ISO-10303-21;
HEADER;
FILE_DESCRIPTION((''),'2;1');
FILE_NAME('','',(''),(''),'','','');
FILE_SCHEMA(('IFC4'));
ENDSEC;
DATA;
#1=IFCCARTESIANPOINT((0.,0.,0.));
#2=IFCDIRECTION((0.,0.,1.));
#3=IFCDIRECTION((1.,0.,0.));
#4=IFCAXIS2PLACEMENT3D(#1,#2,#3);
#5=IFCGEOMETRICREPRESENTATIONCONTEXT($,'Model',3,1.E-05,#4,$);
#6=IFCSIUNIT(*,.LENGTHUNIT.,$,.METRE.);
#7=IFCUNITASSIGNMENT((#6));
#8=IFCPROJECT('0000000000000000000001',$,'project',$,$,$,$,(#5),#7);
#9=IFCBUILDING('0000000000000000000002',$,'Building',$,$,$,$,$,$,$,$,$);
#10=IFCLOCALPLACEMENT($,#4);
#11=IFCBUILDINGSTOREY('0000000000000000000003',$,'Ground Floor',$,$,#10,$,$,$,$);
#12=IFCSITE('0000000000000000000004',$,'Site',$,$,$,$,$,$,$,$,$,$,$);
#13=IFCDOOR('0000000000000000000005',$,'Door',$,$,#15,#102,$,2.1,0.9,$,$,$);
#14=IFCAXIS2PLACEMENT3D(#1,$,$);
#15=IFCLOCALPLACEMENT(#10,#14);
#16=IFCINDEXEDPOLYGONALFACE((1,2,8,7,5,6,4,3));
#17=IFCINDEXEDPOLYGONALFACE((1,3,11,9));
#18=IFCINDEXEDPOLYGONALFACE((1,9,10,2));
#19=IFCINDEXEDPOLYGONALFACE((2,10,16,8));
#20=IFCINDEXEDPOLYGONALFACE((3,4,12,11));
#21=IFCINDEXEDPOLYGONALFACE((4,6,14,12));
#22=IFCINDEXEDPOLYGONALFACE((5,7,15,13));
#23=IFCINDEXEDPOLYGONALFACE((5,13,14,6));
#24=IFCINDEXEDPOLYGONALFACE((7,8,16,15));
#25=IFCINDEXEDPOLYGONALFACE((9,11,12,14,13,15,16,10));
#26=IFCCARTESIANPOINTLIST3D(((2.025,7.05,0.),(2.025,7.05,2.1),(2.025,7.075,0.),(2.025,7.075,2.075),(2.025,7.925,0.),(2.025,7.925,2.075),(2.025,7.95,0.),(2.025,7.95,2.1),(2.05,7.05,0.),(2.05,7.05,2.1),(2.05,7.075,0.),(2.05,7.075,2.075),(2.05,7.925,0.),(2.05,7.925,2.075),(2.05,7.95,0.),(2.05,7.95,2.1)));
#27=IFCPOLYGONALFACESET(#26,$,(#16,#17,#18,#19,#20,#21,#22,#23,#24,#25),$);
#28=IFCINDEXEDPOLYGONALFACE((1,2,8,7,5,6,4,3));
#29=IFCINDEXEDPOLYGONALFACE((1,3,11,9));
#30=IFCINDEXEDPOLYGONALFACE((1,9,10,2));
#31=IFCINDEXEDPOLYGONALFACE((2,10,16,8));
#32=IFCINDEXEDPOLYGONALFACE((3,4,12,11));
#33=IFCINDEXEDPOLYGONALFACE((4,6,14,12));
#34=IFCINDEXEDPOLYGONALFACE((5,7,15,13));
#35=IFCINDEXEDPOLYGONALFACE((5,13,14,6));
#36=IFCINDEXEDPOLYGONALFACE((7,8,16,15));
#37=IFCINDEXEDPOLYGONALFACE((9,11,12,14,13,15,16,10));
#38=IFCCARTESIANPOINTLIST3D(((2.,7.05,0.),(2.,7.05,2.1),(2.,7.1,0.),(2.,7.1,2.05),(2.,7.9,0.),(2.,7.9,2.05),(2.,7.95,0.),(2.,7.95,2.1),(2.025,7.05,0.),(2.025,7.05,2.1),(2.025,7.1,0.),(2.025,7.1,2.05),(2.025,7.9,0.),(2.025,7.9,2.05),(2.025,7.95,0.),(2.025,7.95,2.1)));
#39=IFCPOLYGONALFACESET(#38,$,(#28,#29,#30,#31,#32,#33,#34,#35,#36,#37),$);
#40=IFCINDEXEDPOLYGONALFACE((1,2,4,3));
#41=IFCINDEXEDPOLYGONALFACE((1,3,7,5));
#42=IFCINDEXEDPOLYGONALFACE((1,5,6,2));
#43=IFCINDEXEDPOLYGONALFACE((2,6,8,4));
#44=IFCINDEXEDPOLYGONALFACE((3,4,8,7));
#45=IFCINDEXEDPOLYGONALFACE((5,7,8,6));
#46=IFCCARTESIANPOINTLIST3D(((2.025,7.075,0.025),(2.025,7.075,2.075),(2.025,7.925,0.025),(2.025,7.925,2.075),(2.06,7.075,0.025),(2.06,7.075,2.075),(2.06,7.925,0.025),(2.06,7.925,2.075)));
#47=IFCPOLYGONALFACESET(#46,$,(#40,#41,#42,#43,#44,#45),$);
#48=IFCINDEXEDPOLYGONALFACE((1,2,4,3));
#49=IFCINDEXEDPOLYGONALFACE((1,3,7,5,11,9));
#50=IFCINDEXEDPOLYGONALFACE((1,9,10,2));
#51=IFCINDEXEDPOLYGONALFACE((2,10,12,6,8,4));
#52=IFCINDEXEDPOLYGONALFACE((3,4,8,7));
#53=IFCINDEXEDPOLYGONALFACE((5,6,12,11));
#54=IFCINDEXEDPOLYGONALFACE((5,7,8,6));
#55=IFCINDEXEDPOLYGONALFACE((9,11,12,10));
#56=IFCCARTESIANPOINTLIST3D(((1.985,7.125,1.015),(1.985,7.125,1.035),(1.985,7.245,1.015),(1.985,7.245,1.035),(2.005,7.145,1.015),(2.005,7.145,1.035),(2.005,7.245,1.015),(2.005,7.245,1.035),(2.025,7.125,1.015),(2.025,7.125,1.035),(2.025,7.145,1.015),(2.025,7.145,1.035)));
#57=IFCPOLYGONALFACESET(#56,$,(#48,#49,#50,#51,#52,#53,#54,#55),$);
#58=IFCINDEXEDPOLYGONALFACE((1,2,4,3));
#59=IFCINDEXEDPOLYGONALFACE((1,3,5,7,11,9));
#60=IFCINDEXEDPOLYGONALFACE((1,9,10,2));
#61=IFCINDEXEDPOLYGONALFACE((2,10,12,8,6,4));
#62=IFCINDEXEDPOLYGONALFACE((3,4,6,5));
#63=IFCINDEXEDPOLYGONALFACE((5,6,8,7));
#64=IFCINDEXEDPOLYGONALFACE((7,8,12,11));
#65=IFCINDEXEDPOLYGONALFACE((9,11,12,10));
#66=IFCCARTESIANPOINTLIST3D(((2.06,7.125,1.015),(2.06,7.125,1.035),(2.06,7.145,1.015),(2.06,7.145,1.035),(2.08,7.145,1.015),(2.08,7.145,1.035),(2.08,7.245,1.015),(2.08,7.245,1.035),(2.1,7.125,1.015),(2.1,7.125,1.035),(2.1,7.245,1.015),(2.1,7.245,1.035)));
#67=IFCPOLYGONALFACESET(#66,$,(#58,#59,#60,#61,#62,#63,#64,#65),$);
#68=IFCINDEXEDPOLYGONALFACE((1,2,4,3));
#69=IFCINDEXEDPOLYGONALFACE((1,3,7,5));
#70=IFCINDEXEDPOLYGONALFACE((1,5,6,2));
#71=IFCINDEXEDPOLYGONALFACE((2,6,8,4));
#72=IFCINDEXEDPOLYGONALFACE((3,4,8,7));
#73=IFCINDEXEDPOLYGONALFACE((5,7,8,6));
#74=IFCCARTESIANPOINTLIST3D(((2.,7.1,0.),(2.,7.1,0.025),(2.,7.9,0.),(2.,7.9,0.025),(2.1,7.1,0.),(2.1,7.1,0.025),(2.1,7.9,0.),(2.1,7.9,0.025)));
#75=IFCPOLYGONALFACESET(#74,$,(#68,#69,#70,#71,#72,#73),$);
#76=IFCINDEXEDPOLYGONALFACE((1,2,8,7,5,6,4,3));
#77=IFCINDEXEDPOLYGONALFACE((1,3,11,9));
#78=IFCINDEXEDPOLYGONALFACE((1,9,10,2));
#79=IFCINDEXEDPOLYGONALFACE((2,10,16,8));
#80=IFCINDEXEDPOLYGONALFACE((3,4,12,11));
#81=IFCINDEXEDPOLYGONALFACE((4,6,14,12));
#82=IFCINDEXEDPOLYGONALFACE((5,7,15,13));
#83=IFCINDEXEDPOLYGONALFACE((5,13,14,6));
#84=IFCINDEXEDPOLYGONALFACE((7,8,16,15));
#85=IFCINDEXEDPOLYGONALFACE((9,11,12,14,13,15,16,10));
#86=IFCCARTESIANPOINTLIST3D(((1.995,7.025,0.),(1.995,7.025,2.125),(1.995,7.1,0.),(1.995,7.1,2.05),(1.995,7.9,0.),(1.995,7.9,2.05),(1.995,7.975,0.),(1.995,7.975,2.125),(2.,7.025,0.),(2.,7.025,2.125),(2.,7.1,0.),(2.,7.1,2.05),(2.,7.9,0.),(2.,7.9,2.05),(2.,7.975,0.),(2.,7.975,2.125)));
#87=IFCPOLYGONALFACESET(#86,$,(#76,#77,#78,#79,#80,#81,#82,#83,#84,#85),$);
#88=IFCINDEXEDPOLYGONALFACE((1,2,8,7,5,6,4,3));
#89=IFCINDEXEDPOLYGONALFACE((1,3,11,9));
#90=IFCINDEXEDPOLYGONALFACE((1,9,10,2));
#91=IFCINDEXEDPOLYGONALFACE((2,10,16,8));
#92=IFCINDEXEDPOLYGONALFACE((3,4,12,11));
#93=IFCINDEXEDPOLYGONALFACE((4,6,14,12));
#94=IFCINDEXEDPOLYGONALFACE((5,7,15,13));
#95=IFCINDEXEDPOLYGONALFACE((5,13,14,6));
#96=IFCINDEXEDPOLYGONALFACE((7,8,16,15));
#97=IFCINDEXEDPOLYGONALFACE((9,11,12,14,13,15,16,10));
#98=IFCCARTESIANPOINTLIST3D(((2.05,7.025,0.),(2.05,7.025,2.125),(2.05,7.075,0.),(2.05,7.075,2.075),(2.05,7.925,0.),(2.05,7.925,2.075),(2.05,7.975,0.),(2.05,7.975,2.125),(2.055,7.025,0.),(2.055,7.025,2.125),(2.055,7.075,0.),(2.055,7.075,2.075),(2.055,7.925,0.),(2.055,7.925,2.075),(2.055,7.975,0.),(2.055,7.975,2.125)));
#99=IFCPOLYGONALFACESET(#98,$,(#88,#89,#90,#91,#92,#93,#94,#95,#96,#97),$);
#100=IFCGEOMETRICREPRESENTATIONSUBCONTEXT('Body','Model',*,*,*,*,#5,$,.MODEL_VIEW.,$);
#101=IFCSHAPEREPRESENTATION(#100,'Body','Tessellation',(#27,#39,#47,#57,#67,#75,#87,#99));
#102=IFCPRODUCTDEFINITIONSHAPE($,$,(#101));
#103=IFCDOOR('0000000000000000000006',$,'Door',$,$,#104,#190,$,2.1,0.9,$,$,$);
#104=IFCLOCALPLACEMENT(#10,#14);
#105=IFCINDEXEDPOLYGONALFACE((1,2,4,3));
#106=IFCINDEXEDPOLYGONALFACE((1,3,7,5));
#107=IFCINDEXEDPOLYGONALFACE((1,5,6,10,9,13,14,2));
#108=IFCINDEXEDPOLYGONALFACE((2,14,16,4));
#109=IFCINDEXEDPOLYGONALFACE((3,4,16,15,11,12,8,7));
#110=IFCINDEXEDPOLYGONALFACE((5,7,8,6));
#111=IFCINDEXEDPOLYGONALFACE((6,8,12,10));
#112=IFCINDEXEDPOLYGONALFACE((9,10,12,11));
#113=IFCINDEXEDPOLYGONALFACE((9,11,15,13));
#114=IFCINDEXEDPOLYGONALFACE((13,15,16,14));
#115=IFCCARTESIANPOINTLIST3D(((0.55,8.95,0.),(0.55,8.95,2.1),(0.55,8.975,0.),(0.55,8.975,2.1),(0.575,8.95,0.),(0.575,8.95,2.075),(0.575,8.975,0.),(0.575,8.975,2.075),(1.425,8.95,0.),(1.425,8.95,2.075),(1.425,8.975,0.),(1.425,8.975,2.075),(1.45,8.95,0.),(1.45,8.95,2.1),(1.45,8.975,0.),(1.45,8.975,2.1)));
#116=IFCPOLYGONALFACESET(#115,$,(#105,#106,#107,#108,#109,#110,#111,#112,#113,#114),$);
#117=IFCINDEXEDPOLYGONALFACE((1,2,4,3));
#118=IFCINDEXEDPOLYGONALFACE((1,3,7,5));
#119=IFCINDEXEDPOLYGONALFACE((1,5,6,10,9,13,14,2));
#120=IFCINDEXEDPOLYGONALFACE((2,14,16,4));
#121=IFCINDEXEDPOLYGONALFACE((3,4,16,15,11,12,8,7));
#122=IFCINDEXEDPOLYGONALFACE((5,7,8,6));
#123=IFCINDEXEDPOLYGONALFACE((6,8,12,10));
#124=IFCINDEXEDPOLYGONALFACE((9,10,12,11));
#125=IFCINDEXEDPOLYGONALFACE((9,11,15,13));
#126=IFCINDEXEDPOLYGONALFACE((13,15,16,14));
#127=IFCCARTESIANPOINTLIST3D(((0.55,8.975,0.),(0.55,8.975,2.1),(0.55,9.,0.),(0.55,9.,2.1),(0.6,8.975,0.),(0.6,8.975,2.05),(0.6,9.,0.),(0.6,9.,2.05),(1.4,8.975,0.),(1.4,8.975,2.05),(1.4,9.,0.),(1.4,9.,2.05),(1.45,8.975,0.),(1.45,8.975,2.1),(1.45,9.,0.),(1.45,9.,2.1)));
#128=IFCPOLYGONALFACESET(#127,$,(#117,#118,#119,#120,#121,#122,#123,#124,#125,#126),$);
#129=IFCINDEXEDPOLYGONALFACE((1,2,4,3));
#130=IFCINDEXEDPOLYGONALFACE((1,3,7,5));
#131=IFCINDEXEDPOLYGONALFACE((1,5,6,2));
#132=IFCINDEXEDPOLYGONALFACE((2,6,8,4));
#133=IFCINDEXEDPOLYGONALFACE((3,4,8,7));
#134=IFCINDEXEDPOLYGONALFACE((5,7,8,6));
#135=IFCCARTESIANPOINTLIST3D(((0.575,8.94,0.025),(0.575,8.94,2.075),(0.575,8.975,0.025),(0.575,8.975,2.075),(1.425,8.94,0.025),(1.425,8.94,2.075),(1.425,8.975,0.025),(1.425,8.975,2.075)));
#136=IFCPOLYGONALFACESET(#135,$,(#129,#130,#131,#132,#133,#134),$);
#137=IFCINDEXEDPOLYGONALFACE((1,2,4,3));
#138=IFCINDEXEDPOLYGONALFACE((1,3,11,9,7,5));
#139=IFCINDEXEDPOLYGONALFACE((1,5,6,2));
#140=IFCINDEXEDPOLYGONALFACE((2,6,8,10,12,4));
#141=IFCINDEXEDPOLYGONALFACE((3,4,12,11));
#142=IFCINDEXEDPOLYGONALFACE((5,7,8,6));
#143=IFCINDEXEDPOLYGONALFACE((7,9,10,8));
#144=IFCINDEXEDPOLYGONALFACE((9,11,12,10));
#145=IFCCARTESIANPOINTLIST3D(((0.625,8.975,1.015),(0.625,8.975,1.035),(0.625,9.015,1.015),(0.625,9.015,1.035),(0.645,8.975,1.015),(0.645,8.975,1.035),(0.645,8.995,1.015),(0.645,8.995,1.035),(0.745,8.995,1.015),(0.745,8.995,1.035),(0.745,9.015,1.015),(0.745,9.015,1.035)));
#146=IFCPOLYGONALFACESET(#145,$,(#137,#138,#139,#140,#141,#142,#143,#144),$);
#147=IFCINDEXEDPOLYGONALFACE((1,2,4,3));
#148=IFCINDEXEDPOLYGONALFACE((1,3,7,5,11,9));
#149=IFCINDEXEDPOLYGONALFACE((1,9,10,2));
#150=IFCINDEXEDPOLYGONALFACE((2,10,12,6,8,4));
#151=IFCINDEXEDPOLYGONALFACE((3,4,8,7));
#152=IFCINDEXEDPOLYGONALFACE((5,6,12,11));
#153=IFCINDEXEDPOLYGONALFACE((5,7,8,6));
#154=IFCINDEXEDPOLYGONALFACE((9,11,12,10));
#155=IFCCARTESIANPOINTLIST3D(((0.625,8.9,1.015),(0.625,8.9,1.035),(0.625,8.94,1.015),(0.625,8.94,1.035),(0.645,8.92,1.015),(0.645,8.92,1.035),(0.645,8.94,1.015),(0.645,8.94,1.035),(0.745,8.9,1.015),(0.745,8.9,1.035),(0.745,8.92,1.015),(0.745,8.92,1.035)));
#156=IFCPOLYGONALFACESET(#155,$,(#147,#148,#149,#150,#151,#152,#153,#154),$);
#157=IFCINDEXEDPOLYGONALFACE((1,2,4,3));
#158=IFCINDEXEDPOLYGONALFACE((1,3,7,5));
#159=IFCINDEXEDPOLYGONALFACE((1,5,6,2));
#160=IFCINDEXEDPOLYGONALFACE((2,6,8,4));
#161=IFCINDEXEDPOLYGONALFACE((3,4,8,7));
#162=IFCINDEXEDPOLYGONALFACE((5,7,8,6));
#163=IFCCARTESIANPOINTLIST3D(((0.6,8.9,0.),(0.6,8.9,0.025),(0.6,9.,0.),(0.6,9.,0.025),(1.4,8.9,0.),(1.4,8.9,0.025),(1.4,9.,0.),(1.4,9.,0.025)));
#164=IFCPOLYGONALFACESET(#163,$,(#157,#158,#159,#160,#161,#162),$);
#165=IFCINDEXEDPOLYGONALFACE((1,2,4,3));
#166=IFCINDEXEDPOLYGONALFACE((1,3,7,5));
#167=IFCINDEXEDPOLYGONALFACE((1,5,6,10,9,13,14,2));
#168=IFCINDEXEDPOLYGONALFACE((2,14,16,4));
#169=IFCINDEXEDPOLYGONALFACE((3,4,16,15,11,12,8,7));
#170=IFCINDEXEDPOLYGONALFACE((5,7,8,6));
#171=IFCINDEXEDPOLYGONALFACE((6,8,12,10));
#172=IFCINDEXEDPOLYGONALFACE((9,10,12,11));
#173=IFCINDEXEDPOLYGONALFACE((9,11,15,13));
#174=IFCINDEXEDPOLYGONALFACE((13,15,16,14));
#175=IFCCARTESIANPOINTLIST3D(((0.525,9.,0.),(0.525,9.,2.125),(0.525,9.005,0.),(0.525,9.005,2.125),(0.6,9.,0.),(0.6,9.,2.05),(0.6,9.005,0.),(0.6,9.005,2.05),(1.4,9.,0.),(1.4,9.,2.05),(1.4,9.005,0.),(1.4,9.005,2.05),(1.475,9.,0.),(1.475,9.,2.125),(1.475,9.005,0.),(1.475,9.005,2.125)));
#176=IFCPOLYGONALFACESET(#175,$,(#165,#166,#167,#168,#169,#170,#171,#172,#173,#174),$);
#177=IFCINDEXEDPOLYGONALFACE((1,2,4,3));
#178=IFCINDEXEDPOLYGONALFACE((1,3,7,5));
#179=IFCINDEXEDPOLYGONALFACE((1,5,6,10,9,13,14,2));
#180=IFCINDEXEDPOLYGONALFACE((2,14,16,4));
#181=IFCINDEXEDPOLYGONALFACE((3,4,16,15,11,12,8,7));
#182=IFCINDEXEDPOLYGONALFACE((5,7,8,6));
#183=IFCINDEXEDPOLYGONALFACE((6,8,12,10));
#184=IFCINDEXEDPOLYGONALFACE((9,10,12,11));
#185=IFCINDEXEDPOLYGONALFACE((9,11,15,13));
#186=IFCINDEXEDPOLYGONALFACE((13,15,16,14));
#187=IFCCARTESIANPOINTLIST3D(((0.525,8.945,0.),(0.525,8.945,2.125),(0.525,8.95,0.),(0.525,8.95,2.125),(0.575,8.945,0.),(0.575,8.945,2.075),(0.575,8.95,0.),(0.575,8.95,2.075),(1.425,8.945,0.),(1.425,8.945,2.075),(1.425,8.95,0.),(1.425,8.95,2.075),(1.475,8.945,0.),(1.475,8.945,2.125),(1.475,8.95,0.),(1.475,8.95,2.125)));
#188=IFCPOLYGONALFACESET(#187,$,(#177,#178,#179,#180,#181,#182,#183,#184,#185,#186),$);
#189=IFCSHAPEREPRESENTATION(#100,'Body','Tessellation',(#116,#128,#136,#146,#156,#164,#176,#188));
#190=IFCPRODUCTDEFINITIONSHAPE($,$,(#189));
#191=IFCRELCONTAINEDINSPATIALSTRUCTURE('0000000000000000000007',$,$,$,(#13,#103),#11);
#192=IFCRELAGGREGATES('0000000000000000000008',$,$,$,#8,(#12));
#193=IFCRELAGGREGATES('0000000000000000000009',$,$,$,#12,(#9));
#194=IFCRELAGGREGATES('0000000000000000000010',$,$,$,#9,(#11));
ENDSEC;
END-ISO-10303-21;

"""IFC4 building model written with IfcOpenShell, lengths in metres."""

from ifc_helpers import new_model, si_unit, frame, origin_with_axes, place, context, subcontext, project, spatial, line, indexed_curve, outline, extrude, element, save


model = new_model("IFC4")

# Units and contexts
model_context = context("Model", 3, precision=1e-05, world=origin_with_axes())
body_context = subcontext(model_context, "Body", "Model", "MODEL_VIEW")
ifc_project = project(units=[si_unit("LENGTHUNIT", "METRE")], contexts=[model_context])

# Site, building, storey
site = spatial("IfcSite", under=ifc_project, Name="Site")
building = spatial("IfcBuilding", under=site, Name="Building")
storey_placement = place(None, origin_with_axes())
storey = spatial("IfcBuildingStorey", under=building, at=storey_placement, Name="Ground Floor")

# Doors
door_1_placement = place(storey_placement, frame((2.0, 7.95, 0.0), z_axis=(0.0, 0.0, 1.0), x_axis=(0.0, -1.0, 0.0)))
element("IfcDoor", 1, at=door_1_placement, inside=storey, Name="Door", OverallHeight=2.1, OverallWidth=0.9, context=body_context, shape_type="SweptSolid", body=[
    extrude(outline(indexed_curve([(0.0, 0.0), (0.0, 2.1), (0.9, 2.1), (0.9, 0.0), (0.875, 0.0), (0.875, 2.075), (0.025, 2.075), (0.025, 0.0)], segments=[line(1, 2, 3, 4, 5, 6, 7, 8, 1)])), frame((0.0, 0.025, 0.0), z_axis=(0.0, -1.0, 0.0), x_axis=(1.0, 0.0, 0.0)), (0.0, 0.0, -1.0), 0.025),
    extrude(outline(indexed_curve([(0.0, 0.0), (0.0, 2.1), (0.9, 2.1), (0.9, 0.0), (0.85, 0.0), (0.85, 2.05), (0.05, 2.05), (0.05, 0.0)], segments=[line(1, 2, 3, 4, 5, 6, 7, 8, 1)])), frame((0.0, 0.0, 0.0), z_axis=(0.0, -1.0, 0.0), x_axis=(1.0, 0.0, 0.0)), (0.0, 0.0, -1.0), 0.025),
    extrude(outline(indexed_curve([(0.0, 0.0), (0.85, 0.0), (0.85, 0.035), (0.0, 0.035)], segments=[line(1, 2, 3, 4, 1)])), frame((0.025, 0.025, 0.025), z_axis=(0.0, 0.0, 1.0), x_axis=(1.0, 0.0, 0.0)), (0.0, 0.0, 1.0), 2.05),
    extrude(outline(indexed_curve([(0.0, 0.0), (0.0, -0.04), (-0.12, -0.04), (-0.12, -0.02), (-0.02, -0.02), (-0.02, 0.0)], segments=[line(1, 2, 3, 4, 5, 6, 1)])), frame((0.825, 0.025, 1.015), z_axis=(0.0, 0.0, 1.0), x_axis=(1.0, 0.0, 0.0)), (0.0, 0.0, 1.0), 0.02),
    extrude(outline(indexed_curve([(0.0, 0.0), (0.0, 0.04), (-0.12, 0.04), (-0.12, 0.02), (-0.02, 0.02), (-0.02, 0.0)], segments=[line(1, 2, 3, 4, 5, 6, 1)])), frame((0.825, 0.06, 1.015), z_axis=(0.0, 0.0, 1.0), x_axis=(1.0, 0.0, 0.0)), (0.0, 0.0, 1.0), 0.02),
    extrude(outline(indexed_curve([(0.0, 0.0), (0.8, 0.0), (0.8, 0.1), (0.0, 0.1)], segments=[line(1, 2, 3, 4, 1)])), frame((0.05, 0.0, 0.0), z_axis=(0.0, 0.0, 1.0), x_axis=(1.0, 0.0, 0.0)), (0.0, 0.0, 1.0), 0.025),
    extrude(outline(indexed_curve([(0.0, 0.0), (0.0, 2.125), (0.95, 2.125), (0.95, 0.0), (0.875, 0.0), (0.875, 2.05), (0.075, 2.05), (0.075, 0.0)], segments=[line(1, 2, 3, 4, 5, 6, 7, 8, 1)])), frame((-0.025, -0.005, 0.0), z_axis=(0.0, -1.0, 0.0), x_axis=(1.0, 0.0, 0.0)), (0.0, 0.0, -1.0), 0.005),
    extrude(outline(indexed_curve([(0.0, 0.0), (0.0, 2.125), (0.95, 2.125), (0.95, 0.0), (0.9, 0.0), (0.9, 2.075), (0.05, 2.075), (0.05, 0.0)], segments=[line(1, 2, 3, 4, 5, 6, 7, 8, 1)])), frame((-0.025, 0.05, 0.0), z_axis=(0.0, -1.0, 0.0), x_axis=(1.0, 0.0, 0.0)), (0.0, 0.0, -1.0), 0.005),
])
door_2_placement = place(storey_placement, frame((1.45, 9.0, 0.0), z_axis=(0.0, 0.0, 1.0), x_axis=(-1.0, 0.0, 0.0)))
element("IfcDoor", 2, at=door_2_placement, inside=storey, Name="Door", OverallHeight=2.1, OverallWidth=0.9, context=body_context, shape_type="SweptSolid", body=[
    extrude(outline(indexed_curve([(0.0, 0.0), (0.0, 2.1), (0.9, 2.1), (0.9, 0.0), (0.875, 0.0), (0.875, 2.075), (0.025, 2.075), (0.025, 0.0)], segments=[line(1, 2, 3, 4, 5, 6, 7, 8, 1)])), frame((0.0, 0.025, 0.0), z_axis=(0.0, -1.0, 0.0), x_axis=(1.0, 0.0, 0.0)), (0.0, 0.0, -1.0), 0.025),
    extrude(outline(indexed_curve([(0.0, 0.0), (0.0, 2.1), (0.9, 2.1), (0.9, 0.0), (0.85, 0.0), (0.85, 2.05), (0.05, 2.05), (0.05, 0.0)], segments=[line(1, 2, 3, 4, 5, 6, 7, 8, 1)])), frame((0.0, 0.0, 0.0), z_axis=(0.0, -1.0, 0.0), x_axis=(1.0, 0.0, 0.0)), (0.0, 0.0, -1.0), 0.025),
    extrude(outline(indexed_curve([(0.0, 0.0), (0.85, 0.0), (0.85, 0.035), (0.0, 0.035)], segments=[line(1, 2, 3, 4, 1)])), frame((0.025, 0.025, 0.025), z_axis=(0.0, 0.0, 1.0), x_axis=(1.0, 0.0, 0.0)), (0.0, 0.0, 1.0), 2.05),
    extrude(outline(indexed_curve([(0.0, 0.0), (0.0, -0.04), (-0.12, -0.04), (-0.12, -0.02), (-0.02, -0.02), (-0.02, 0.0)], segments=[line(1, 2, 3, 4, 5, 6, 1)])), frame((0.825, 0.025, 1.015), z_axis=(0.0, 0.0, 1.0), x_axis=(1.0, 0.0, 0.0)), (0.0, 0.0, 1.0), 0.02),
    extrude(outline(indexed_curve([(0.0, 0.0), (0.0, 0.04), (-0.12, 0.04), (-0.12, 0.02), (-0.02, 0.02), (-0.02, 0.0)], segments=[line(1, 2, 3, 4, 5, 6, 1)])), frame((0.825, 0.06, 1.015), z_axis=(0.0, 0.0, 1.0), x_axis=(1.0, 0.0, 0.0)), (0.0, 0.0, 1.0), 0.02),
    extrude(outline(indexed_curve([(0.0, 0.0), (0.8, 0.0), (0.8, 0.1), (0.0, 0.1)], segments=[line(1, 2, 3, 4, 1)])), frame((0.05, 0.0, 0.0), z_axis=(0.0, 0.0, 1.0), x_axis=(1.0, 0.0, 0.0)), (0.0, 0.0, 1.0), 0.025),
    extrude(outline(indexed_curve([(0.0, 0.0), (0.0, 2.125), (0.95, 2.125), (0.95, 0.0), (0.875, 0.0), (0.875, 2.05), (0.075, 2.05), (0.075, 0.0)], segments=[line(1, 2, 3, 4, 5, 6, 7, 8, 1)])), frame((-0.025, -0.005, 0.0), z_axis=(0.0, -1.0, 0.0), x_axis=(1.0, 0.0, 0.0)), (0.0, 0.0, -1.0), 0.005),
    extrude(outline(indexed_curve([(0.0, 0.0), (0.0, 2.125), (0.95, 2.125), (0.95, 0.0), (0.9, 0.0), (0.9, 2.075), (0.05, 2.075), (0.05, 0.0)], segments=[line(1, 2, 3, 4, 5, 6, 7, 8, 1)])), frame((-0.025, 0.05, 0.0), z_axis=(0.0, -1.0, 0.0), x_axis=(1.0, 0.0, 0.0)), (0.0, 0.0, -1.0), 0.005),
])

save(model, "model.ifc")
